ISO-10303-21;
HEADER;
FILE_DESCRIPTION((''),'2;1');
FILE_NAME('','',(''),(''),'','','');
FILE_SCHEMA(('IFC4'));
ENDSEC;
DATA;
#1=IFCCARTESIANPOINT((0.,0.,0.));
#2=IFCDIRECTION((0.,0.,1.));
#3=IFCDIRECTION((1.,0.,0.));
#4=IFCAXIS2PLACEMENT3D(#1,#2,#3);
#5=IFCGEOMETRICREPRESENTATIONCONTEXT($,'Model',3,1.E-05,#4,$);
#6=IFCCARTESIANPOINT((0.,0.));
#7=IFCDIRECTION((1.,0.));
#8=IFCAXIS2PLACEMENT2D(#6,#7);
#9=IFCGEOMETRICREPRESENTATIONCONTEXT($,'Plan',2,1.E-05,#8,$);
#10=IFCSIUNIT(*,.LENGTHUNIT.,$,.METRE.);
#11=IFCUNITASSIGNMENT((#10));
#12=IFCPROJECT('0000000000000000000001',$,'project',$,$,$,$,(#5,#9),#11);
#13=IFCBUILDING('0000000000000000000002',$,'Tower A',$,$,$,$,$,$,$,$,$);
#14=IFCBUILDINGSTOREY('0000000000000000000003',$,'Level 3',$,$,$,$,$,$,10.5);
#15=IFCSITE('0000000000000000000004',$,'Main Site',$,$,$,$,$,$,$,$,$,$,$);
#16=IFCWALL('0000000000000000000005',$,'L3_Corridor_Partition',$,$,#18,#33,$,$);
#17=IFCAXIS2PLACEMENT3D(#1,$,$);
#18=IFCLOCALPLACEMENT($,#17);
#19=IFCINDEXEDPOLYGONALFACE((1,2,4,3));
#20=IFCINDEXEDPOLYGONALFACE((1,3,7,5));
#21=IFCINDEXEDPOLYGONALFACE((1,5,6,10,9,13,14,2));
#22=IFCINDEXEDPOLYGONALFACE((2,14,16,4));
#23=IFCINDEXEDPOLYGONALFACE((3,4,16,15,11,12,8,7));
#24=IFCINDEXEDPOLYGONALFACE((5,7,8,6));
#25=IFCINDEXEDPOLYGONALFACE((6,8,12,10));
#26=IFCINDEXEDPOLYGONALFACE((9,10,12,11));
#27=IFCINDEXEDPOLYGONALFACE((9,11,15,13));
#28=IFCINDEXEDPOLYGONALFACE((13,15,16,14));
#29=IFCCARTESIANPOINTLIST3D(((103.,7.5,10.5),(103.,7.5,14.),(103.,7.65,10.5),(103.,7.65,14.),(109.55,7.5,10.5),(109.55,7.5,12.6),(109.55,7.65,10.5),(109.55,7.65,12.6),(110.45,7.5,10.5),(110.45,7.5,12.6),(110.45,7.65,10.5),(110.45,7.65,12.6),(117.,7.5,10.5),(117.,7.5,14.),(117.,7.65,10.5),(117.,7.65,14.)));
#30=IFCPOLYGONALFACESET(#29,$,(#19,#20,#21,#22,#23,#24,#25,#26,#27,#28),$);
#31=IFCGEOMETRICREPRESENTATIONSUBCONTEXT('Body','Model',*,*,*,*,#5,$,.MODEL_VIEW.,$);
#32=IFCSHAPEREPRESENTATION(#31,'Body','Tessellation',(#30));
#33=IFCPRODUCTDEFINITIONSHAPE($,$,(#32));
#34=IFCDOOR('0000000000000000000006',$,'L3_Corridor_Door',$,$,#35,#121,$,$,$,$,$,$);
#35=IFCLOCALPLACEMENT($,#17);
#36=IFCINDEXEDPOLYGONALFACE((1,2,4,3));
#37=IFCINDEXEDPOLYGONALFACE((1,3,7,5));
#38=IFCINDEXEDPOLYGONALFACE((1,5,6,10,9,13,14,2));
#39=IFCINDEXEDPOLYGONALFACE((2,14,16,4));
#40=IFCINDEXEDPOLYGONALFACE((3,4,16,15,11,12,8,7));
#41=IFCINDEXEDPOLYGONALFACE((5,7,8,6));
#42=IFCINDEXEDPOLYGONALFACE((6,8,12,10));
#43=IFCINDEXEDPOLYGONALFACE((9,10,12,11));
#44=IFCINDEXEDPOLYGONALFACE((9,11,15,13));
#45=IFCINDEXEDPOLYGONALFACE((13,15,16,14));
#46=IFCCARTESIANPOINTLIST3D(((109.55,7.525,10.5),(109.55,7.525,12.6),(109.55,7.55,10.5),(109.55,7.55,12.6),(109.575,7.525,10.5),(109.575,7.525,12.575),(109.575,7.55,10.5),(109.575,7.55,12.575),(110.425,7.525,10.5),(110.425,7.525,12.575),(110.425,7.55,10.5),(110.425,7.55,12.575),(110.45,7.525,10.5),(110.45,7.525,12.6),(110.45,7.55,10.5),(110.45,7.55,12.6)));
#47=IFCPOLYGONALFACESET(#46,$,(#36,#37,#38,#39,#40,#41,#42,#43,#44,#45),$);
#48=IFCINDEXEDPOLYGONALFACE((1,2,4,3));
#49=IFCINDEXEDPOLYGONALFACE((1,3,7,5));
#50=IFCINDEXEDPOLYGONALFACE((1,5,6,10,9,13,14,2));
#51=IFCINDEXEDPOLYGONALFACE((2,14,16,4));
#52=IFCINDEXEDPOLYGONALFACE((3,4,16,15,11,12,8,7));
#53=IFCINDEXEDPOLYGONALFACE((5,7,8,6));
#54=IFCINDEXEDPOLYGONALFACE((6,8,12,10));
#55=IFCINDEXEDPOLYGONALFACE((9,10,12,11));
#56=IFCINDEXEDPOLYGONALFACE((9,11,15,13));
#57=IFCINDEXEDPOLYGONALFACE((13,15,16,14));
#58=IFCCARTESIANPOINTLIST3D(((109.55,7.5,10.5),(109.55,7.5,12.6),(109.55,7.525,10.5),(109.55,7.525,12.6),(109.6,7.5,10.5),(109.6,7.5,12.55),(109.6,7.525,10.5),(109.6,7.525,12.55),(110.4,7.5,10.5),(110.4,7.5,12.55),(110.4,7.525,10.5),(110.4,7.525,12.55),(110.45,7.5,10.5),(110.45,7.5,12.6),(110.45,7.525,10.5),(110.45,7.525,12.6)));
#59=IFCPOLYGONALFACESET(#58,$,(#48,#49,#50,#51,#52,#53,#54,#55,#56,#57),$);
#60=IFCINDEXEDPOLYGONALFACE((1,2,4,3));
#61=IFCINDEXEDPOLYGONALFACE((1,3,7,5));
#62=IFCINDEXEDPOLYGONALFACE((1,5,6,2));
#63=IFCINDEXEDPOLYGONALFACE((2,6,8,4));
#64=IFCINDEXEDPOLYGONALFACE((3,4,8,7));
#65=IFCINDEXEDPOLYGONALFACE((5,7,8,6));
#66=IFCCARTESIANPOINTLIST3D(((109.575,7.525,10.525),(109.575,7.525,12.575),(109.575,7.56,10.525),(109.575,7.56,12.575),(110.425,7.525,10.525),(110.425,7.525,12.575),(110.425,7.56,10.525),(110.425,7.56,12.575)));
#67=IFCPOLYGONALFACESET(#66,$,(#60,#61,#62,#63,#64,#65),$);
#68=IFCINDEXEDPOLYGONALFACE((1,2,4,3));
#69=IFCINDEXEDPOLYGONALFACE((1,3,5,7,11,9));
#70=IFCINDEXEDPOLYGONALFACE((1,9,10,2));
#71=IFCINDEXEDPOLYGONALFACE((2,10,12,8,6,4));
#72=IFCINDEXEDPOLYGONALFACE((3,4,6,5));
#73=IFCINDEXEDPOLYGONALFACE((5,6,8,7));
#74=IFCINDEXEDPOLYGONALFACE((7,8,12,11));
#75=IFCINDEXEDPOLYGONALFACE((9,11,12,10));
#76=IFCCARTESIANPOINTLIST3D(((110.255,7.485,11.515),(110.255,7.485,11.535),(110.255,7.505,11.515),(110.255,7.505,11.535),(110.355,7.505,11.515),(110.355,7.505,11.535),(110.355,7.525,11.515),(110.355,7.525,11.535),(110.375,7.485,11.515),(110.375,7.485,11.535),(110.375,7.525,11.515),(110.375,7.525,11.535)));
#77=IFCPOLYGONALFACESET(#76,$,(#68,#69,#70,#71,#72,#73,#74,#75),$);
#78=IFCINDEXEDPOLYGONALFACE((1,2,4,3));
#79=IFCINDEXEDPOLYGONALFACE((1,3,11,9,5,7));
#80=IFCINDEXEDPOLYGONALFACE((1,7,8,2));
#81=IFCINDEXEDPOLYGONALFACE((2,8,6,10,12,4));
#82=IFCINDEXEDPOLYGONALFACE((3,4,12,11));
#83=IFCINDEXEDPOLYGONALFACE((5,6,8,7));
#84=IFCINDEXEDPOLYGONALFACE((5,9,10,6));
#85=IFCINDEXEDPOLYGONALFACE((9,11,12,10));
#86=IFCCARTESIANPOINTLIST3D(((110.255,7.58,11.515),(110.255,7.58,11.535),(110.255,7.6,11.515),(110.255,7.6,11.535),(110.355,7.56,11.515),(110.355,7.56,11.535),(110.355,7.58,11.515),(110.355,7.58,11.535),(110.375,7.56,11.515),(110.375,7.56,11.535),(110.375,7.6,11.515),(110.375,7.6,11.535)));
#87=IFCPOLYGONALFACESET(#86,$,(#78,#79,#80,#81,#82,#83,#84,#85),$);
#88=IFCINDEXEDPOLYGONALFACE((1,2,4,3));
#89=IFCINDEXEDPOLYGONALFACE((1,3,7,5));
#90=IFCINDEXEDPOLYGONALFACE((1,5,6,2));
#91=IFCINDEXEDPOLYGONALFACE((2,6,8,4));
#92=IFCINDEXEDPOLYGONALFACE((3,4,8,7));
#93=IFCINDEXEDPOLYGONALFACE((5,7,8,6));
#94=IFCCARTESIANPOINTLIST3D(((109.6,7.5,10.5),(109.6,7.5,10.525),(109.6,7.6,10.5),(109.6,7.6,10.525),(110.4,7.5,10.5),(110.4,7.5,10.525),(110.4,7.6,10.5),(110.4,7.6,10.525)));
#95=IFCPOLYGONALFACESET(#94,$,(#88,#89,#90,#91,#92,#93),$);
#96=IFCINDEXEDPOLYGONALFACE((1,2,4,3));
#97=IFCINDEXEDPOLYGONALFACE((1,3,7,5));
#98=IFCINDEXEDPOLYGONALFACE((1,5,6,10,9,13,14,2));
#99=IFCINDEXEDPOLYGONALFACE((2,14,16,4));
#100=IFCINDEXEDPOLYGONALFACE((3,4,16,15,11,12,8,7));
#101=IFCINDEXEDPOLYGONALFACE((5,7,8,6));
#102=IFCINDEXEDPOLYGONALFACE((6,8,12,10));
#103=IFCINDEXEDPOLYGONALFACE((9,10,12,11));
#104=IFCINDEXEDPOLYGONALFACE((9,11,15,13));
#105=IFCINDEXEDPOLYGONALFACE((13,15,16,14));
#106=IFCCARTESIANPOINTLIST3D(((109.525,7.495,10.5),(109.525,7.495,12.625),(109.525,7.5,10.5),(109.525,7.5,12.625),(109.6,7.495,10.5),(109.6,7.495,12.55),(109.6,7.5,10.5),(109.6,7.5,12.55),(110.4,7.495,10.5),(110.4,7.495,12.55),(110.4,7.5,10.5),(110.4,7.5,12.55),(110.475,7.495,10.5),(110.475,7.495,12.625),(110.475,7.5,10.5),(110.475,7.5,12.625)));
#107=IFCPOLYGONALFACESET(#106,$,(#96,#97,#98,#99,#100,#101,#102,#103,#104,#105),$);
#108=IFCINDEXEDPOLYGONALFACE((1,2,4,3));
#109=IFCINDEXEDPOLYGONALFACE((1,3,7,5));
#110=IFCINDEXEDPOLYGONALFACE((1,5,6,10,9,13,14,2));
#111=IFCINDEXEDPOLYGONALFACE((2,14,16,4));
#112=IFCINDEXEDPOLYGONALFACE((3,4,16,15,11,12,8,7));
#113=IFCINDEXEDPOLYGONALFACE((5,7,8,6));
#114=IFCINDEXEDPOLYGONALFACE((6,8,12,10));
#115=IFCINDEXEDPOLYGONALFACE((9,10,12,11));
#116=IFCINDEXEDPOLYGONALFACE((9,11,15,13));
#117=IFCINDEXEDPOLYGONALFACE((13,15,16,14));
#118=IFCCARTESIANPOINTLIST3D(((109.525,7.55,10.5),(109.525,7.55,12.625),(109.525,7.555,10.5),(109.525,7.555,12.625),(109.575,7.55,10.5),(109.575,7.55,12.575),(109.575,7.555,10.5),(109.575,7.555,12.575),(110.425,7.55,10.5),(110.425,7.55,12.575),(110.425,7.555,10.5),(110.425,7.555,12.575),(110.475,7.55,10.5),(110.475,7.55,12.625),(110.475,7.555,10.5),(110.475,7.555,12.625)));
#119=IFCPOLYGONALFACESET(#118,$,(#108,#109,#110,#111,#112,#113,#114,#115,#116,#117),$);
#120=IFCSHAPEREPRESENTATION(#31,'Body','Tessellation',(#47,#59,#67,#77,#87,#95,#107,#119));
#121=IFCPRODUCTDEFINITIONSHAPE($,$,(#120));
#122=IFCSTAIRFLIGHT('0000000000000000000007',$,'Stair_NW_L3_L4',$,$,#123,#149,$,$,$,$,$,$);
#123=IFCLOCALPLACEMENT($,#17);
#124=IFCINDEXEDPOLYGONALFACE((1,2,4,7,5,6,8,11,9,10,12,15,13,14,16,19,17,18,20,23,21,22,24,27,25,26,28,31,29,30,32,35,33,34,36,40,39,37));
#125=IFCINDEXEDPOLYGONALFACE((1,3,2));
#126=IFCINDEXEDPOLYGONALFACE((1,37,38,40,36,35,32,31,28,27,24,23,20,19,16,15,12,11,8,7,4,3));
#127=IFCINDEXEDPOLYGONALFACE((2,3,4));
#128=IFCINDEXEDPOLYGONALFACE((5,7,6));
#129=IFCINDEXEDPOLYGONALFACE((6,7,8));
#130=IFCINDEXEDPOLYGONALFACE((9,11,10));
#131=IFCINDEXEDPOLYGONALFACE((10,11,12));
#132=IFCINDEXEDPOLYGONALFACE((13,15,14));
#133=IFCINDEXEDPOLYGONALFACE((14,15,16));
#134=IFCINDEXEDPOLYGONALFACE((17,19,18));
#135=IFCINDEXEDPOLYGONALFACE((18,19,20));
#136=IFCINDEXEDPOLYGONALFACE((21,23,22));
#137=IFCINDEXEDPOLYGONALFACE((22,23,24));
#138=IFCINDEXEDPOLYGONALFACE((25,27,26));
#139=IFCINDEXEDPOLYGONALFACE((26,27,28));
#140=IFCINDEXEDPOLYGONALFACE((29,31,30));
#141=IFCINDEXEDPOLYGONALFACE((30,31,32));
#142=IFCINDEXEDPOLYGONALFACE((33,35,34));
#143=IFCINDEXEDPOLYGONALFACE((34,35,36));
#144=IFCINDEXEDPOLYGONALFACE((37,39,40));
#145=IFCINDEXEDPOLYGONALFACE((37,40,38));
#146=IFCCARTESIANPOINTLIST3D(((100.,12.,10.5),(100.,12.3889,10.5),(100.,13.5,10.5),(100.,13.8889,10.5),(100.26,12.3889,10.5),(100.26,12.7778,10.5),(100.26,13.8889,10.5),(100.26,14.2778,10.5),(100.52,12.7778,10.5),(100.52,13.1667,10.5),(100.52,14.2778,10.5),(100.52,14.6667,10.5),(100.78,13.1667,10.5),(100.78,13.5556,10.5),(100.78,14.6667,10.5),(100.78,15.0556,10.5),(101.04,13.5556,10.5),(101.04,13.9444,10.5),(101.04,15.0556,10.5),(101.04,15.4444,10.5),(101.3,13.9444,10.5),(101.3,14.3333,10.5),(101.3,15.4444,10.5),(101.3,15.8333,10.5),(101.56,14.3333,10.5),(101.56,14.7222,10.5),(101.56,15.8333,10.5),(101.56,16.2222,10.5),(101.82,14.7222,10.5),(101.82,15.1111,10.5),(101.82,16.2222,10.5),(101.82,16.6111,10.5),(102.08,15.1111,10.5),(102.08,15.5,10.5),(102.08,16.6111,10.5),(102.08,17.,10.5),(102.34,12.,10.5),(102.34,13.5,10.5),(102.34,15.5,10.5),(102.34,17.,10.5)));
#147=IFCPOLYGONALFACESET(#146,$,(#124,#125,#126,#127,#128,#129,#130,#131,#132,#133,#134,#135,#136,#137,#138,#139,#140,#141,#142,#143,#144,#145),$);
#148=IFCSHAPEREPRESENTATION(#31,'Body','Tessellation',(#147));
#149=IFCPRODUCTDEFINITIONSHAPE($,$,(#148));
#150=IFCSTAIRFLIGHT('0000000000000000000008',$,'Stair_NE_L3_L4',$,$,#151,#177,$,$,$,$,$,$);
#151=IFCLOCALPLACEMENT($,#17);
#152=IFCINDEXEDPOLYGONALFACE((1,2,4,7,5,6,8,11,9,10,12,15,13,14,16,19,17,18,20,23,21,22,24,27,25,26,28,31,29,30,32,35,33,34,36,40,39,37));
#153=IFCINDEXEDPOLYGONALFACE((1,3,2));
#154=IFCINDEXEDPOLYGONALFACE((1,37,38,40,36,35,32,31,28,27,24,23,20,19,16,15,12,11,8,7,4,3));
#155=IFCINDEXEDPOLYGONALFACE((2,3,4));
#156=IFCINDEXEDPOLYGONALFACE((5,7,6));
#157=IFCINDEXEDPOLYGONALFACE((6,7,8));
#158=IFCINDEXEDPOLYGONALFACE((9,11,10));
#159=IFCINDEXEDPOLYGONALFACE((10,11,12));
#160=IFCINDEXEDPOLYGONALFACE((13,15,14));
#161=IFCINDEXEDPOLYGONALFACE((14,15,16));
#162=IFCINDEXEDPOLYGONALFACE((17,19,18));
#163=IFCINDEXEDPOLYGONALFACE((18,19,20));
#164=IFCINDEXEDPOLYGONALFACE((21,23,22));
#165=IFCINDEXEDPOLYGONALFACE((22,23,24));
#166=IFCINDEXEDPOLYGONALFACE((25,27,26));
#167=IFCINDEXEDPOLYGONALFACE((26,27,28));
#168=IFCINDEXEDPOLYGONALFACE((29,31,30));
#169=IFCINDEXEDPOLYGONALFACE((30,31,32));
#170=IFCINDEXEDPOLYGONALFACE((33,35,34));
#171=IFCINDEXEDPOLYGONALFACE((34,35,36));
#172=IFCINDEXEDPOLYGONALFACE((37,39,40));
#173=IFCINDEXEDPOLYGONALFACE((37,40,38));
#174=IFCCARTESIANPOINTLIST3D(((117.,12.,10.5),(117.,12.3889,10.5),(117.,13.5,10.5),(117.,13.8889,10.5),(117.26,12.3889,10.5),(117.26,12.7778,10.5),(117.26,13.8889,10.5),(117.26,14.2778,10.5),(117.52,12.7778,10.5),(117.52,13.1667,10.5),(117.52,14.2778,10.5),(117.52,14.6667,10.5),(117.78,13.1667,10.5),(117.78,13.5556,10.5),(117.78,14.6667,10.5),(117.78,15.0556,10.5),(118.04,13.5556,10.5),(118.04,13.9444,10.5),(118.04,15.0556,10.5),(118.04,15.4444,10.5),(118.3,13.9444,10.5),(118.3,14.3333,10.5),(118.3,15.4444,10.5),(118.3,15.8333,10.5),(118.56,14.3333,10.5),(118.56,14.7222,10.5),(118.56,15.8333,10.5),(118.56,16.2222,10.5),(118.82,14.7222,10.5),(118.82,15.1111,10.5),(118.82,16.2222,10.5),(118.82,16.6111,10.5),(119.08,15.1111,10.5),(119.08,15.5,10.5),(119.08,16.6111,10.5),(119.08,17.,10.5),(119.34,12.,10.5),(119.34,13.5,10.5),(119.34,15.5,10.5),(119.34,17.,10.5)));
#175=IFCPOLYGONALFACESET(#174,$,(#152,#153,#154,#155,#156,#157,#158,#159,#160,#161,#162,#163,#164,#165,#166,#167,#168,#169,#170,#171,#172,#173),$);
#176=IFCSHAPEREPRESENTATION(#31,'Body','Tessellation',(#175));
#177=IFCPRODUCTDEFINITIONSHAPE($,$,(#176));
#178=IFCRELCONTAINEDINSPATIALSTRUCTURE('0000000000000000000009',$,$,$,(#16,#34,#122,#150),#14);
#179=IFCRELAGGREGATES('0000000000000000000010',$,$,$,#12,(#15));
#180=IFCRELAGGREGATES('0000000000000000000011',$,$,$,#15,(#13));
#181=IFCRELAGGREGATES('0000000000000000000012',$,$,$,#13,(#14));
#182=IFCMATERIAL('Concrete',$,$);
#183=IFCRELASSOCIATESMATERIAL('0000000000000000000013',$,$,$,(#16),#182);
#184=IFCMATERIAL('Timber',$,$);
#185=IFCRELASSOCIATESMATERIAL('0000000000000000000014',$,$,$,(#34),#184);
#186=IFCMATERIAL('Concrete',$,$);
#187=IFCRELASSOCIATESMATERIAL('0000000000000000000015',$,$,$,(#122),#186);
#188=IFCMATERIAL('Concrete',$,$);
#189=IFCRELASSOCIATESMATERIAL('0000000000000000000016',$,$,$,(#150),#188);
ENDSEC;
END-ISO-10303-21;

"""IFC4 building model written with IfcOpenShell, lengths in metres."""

from ifc_helpers import new_model, si_unit, frame, origin_with_axes, origin_2d_with_axis, place, context, subcontext, project, spatial, line, indexed_curve, outline, extrude, material, element, fill, save


model = new_model("IFC4")

# Units and contexts
model_context = context("Model", 3, precision=1e-05, world=origin_with_axes())
plan_context = context("Plan", 2, precision=1e-05, world=origin_2d_with_axis())
body_context = subcontext(model_context, "Body", "Model", "MODEL_VIEW")
ifc_project = project(units=[si_unit("LENGTHUNIT", "METRE")], contexts=[model_context, plan_context])

# Site, building, storey
site = spatial("IfcSite", under=ifc_project, Name="Main Site")
building = spatial("IfcBuilding", under=site, Name="Tower A")
storey = spatial("IfcBuildingStorey", under=building, Name="Level 3", Elevation=10.5)

# Wall, opening, door
ifc_material_1 = material(Name="Concrete")
wall_1_placement = place(None, frame((103.0, 7.5, 10.5), z_axis=(0.0, 0.0, 1.0), x_axis=(1.0, 0.0, 0.0)))
wall_1 = element("IfcWall", 1, at=wall_1_placement, inside=storey, material=ifc_material_1, Name="L3_Corridor_Partition", context=body_context, shape_type="SweptSolid", body=[
    extrude(outline(indexed_curve([(0.0, 0.0), (0.0, 0.15), (14.0, 0.15), (14.0, 0.0), (0.0, 0.0)], self_intersect=False)), origin_with_axes(), (0.0, 0.0, 1.0), 3.5),
])
opening_1_placement = place(wall_1_placement, frame((6.55, 0.0, 0.0), z_axis=(0.0, 0.0, 1.0), x_axis=(1.0, 0.0, 0.0)))
opening_1 = element("IfcOpeningElement", 2, at=opening_1_placement, cuts=wall_1, context=body_context, shape_type="SweptSolid", body=[
    extrude(outline(indexed_curve([(0.0, 0.0), (0.0, 0.2), (0.9, 0.2), (0.9, 0.0), (0.0, 0.0)], self_intersect=False)), origin_with_axes(), (0.0, 0.0, 1.0), 2.1),
])
ifc_material_2 = material(Name="Timber")
door_placement = place(None, frame((109.55, 7.5, 10.5), z_axis=(0.0, 0.0, 1.0), x_axis=(1.0, 0.0, 0.0)))
door = element("IfcDoor", 3, at=door_placement, inside=storey, material=ifc_material_2, Name="L3_Corridor_Door", context=body_context, shape_type="SweptSolid", body=[
    extrude(outline(indexed_curve([(0.0, 0.0), (0.0, 2.1), (0.9, 2.1), (0.9, 0.0), (0.875, 0.0), (0.875, 2.075), (0.025, 2.075), (0.025, 0.0)], segments=[line(1, 2, 3, 4, 5, 6, 7, 8, 1)])), frame((0.0, 0.025, 0.0), z_axis=(0.0, -1.0, 0.0), x_axis=(1.0, 0.0, 0.0)), (0.0, 0.0, -1.0), 0.025),
    extrude(outline(indexed_curve([(0.0, 0.0), (0.0, 2.1), (0.9, 2.1), (0.9, 0.0), (0.85, 0.0), (0.85, 2.05), (0.05, 2.05), (0.05, 0.0)], segments=[line(1, 2, 3, 4, 5, 6, 7, 8, 1)])), frame((0.0, 0.0, 0.0), z_axis=(0.0, -1.0, 0.0), x_axis=(1.0, 0.0, 0.0)), (0.0, 0.0, -1.0), 0.025),
    extrude(outline(indexed_curve([(0.0, 0.0), (0.85, 0.0), (0.85, 0.035), (0.0, 0.035)], segments=[line(1, 2, 3, 4, 1)])), frame((0.025, 0.025, 0.025), z_axis=(0.0, 0.0, 1.0), x_axis=(1.0, 0.0, 0.0)), (0.0, 0.0, 1.0), 2.05),
    extrude(outline(indexed_curve([(0.0, 0.0), (0.0, -0.04), (-0.12, -0.04), (-0.12, -0.02), (-0.02, -0.02), (-0.02, 0.0)], segments=[line(1, 2, 3, 4, 5, 6, 1)])), frame((0.825, 0.025, 1.015), z_axis=(0.0, 0.0, 1.0), x_axis=(1.0, 0.0, 0.0)), (0.0, 0.0, 1.0), 0.02),
    extrude(outline(indexed_curve([(0.0, 0.0), (0.0, 0.04), (-0.12, 0.04), (-0.12, 0.02), (-0.02, 0.02), (-0.02, 0.0)], segments=[line(1, 2, 3, 4, 5, 6, 1)])), frame((0.825, 0.06, 1.015), z_axis=(0.0, 0.0, 1.0), x_axis=(1.0, 0.0, 0.0)), (0.0, 0.0, 1.0), 0.02),
    extrude(outline(indexed_curve([(0.0, 0.0), (0.8, 0.0), (0.8, 0.1), (0.0, 0.1)], segments=[line(1, 2, 3, 4, 1)])), frame((0.05, 0.0, 0.0), z_axis=(0.0, 0.0, 1.0), x_axis=(1.0, 0.0, 0.0)), (0.0, 0.0, 1.0), 0.025),
    extrude(outline(indexed_curve([(0.0, 0.0), (0.0, 2.125), (0.95, 2.125), (0.95, 0.0), (0.875, 0.0), (0.875, 2.05), (0.075, 2.05), (0.075, 0.0)], segments=[line(1, 2, 3, 4, 5, 6, 7, 8, 1)])), frame((-0.025, -0.005, 0.0), z_axis=(0.0, -1.0, 0.0), x_axis=(1.0, 0.0, 0.0)), (0.0, 0.0, -1.0), 0.005),
    extrude(outline(indexed_curve([(0.0, 0.0), (0.0, 2.125), (0.95, 2.125), (0.95, 0.0), (0.9, 0.0), (0.9, 2.075), (0.05, 2.075), (0.05, 0.0)], segments=[line(1, 2, 3, 4, 5, 6, 7, 8, 1)])), frame((-0.025, 0.05, 0.0), z_axis=(0.0, -1.0, 0.0), x_axis=(1.0, 0.0, 0.0)), (0.0, 0.0, -1.0), 0.005),
])
fill(opening_1, door)

# Stair flights
ifc_material_3 = material(Name="Concrete")
stair_flight_1_placement = place(None, frame((100.0, 12.0, 10.5), z_axis=(0.0, 0.0, 1.0), x_axis=(1.0, 0.0, 0.0)))
element("IfcStairFlight", 4, at=stair_flight_1_placement, inside=storey, material=ifc_material_3, Name="Stair_NW_L3_L4", context=body_context, shape_type="SweptSolid", body=[
    extrude(outline(indexed_curve([(0.0, 0.0), (0.0, 0.3889), (0.26, 0.3889), (0.26, 0.7778), (0.52, 0.7778), (0.52, 1.1667), (0.78, 1.1667), (0.78, 1.5556), (1.04, 1.5556), (1.04, 1.9444), (1.3, 1.9444), (1.3, 2.3333), (1.56, 2.3333), (1.56, 2.7222), (1.82, 2.7222), (1.82, 3.1111), (2.08, 3.1111), (2.08, 3.5), (2.34, 3.5), (2.34, 0.0)], segments=[line(1, 2, 3, 4, 5, 6, 7, 8, 9, 10, 11, 12, 13, 14, 15, 16, 17, 18, 19, 20, 1)])), origin_with_axes(), (0.0, 1.0, 0.0), 1.5),
])
ifc_material_4 = material(Name="Concrete")
stair_flight_2_placement = place(None, frame((117.0, 12.0, 10.5), z_axis=(0.0, 0.0, 1.0), x_axis=(1.0, 0.0, 0.0)))
element("IfcStairFlight", 5, at=stair_flight_2_placement, inside=storey, material=ifc_material_4, Name="Stair_NE_L3_L4", context=body_context, shape_type="SweptSolid", body=[
    extrude(outline(indexed_curve([(0.0, 0.0), (0.0, 0.3889), (0.26, 0.3889), (0.26, 0.7778), (0.52, 0.7778), (0.52, 1.1667), (0.78, 1.1667), (0.78, 1.5556), (1.04, 1.5556), (1.04, 1.9444), (1.3, 1.9444), (1.3, 2.3333), (1.56, 2.3333), (1.56, 2.7222), (1.82, 2.7222), (1.82, 3.1111), (2.08, 3.1111), (2.08, 3.5), (2.34, 3.5), (2.34, 0.0)], segments=[line(1, 2, 3, 4, 5, 6, 7, 8, 9, 10, 11, 12, 13, 14, 15, 16, 17, 18, 19, 20, 1)])), origin_with_axes(), (0.0, 1.0, 0.0), 1.5),
])

save(model, "model.ifc")
